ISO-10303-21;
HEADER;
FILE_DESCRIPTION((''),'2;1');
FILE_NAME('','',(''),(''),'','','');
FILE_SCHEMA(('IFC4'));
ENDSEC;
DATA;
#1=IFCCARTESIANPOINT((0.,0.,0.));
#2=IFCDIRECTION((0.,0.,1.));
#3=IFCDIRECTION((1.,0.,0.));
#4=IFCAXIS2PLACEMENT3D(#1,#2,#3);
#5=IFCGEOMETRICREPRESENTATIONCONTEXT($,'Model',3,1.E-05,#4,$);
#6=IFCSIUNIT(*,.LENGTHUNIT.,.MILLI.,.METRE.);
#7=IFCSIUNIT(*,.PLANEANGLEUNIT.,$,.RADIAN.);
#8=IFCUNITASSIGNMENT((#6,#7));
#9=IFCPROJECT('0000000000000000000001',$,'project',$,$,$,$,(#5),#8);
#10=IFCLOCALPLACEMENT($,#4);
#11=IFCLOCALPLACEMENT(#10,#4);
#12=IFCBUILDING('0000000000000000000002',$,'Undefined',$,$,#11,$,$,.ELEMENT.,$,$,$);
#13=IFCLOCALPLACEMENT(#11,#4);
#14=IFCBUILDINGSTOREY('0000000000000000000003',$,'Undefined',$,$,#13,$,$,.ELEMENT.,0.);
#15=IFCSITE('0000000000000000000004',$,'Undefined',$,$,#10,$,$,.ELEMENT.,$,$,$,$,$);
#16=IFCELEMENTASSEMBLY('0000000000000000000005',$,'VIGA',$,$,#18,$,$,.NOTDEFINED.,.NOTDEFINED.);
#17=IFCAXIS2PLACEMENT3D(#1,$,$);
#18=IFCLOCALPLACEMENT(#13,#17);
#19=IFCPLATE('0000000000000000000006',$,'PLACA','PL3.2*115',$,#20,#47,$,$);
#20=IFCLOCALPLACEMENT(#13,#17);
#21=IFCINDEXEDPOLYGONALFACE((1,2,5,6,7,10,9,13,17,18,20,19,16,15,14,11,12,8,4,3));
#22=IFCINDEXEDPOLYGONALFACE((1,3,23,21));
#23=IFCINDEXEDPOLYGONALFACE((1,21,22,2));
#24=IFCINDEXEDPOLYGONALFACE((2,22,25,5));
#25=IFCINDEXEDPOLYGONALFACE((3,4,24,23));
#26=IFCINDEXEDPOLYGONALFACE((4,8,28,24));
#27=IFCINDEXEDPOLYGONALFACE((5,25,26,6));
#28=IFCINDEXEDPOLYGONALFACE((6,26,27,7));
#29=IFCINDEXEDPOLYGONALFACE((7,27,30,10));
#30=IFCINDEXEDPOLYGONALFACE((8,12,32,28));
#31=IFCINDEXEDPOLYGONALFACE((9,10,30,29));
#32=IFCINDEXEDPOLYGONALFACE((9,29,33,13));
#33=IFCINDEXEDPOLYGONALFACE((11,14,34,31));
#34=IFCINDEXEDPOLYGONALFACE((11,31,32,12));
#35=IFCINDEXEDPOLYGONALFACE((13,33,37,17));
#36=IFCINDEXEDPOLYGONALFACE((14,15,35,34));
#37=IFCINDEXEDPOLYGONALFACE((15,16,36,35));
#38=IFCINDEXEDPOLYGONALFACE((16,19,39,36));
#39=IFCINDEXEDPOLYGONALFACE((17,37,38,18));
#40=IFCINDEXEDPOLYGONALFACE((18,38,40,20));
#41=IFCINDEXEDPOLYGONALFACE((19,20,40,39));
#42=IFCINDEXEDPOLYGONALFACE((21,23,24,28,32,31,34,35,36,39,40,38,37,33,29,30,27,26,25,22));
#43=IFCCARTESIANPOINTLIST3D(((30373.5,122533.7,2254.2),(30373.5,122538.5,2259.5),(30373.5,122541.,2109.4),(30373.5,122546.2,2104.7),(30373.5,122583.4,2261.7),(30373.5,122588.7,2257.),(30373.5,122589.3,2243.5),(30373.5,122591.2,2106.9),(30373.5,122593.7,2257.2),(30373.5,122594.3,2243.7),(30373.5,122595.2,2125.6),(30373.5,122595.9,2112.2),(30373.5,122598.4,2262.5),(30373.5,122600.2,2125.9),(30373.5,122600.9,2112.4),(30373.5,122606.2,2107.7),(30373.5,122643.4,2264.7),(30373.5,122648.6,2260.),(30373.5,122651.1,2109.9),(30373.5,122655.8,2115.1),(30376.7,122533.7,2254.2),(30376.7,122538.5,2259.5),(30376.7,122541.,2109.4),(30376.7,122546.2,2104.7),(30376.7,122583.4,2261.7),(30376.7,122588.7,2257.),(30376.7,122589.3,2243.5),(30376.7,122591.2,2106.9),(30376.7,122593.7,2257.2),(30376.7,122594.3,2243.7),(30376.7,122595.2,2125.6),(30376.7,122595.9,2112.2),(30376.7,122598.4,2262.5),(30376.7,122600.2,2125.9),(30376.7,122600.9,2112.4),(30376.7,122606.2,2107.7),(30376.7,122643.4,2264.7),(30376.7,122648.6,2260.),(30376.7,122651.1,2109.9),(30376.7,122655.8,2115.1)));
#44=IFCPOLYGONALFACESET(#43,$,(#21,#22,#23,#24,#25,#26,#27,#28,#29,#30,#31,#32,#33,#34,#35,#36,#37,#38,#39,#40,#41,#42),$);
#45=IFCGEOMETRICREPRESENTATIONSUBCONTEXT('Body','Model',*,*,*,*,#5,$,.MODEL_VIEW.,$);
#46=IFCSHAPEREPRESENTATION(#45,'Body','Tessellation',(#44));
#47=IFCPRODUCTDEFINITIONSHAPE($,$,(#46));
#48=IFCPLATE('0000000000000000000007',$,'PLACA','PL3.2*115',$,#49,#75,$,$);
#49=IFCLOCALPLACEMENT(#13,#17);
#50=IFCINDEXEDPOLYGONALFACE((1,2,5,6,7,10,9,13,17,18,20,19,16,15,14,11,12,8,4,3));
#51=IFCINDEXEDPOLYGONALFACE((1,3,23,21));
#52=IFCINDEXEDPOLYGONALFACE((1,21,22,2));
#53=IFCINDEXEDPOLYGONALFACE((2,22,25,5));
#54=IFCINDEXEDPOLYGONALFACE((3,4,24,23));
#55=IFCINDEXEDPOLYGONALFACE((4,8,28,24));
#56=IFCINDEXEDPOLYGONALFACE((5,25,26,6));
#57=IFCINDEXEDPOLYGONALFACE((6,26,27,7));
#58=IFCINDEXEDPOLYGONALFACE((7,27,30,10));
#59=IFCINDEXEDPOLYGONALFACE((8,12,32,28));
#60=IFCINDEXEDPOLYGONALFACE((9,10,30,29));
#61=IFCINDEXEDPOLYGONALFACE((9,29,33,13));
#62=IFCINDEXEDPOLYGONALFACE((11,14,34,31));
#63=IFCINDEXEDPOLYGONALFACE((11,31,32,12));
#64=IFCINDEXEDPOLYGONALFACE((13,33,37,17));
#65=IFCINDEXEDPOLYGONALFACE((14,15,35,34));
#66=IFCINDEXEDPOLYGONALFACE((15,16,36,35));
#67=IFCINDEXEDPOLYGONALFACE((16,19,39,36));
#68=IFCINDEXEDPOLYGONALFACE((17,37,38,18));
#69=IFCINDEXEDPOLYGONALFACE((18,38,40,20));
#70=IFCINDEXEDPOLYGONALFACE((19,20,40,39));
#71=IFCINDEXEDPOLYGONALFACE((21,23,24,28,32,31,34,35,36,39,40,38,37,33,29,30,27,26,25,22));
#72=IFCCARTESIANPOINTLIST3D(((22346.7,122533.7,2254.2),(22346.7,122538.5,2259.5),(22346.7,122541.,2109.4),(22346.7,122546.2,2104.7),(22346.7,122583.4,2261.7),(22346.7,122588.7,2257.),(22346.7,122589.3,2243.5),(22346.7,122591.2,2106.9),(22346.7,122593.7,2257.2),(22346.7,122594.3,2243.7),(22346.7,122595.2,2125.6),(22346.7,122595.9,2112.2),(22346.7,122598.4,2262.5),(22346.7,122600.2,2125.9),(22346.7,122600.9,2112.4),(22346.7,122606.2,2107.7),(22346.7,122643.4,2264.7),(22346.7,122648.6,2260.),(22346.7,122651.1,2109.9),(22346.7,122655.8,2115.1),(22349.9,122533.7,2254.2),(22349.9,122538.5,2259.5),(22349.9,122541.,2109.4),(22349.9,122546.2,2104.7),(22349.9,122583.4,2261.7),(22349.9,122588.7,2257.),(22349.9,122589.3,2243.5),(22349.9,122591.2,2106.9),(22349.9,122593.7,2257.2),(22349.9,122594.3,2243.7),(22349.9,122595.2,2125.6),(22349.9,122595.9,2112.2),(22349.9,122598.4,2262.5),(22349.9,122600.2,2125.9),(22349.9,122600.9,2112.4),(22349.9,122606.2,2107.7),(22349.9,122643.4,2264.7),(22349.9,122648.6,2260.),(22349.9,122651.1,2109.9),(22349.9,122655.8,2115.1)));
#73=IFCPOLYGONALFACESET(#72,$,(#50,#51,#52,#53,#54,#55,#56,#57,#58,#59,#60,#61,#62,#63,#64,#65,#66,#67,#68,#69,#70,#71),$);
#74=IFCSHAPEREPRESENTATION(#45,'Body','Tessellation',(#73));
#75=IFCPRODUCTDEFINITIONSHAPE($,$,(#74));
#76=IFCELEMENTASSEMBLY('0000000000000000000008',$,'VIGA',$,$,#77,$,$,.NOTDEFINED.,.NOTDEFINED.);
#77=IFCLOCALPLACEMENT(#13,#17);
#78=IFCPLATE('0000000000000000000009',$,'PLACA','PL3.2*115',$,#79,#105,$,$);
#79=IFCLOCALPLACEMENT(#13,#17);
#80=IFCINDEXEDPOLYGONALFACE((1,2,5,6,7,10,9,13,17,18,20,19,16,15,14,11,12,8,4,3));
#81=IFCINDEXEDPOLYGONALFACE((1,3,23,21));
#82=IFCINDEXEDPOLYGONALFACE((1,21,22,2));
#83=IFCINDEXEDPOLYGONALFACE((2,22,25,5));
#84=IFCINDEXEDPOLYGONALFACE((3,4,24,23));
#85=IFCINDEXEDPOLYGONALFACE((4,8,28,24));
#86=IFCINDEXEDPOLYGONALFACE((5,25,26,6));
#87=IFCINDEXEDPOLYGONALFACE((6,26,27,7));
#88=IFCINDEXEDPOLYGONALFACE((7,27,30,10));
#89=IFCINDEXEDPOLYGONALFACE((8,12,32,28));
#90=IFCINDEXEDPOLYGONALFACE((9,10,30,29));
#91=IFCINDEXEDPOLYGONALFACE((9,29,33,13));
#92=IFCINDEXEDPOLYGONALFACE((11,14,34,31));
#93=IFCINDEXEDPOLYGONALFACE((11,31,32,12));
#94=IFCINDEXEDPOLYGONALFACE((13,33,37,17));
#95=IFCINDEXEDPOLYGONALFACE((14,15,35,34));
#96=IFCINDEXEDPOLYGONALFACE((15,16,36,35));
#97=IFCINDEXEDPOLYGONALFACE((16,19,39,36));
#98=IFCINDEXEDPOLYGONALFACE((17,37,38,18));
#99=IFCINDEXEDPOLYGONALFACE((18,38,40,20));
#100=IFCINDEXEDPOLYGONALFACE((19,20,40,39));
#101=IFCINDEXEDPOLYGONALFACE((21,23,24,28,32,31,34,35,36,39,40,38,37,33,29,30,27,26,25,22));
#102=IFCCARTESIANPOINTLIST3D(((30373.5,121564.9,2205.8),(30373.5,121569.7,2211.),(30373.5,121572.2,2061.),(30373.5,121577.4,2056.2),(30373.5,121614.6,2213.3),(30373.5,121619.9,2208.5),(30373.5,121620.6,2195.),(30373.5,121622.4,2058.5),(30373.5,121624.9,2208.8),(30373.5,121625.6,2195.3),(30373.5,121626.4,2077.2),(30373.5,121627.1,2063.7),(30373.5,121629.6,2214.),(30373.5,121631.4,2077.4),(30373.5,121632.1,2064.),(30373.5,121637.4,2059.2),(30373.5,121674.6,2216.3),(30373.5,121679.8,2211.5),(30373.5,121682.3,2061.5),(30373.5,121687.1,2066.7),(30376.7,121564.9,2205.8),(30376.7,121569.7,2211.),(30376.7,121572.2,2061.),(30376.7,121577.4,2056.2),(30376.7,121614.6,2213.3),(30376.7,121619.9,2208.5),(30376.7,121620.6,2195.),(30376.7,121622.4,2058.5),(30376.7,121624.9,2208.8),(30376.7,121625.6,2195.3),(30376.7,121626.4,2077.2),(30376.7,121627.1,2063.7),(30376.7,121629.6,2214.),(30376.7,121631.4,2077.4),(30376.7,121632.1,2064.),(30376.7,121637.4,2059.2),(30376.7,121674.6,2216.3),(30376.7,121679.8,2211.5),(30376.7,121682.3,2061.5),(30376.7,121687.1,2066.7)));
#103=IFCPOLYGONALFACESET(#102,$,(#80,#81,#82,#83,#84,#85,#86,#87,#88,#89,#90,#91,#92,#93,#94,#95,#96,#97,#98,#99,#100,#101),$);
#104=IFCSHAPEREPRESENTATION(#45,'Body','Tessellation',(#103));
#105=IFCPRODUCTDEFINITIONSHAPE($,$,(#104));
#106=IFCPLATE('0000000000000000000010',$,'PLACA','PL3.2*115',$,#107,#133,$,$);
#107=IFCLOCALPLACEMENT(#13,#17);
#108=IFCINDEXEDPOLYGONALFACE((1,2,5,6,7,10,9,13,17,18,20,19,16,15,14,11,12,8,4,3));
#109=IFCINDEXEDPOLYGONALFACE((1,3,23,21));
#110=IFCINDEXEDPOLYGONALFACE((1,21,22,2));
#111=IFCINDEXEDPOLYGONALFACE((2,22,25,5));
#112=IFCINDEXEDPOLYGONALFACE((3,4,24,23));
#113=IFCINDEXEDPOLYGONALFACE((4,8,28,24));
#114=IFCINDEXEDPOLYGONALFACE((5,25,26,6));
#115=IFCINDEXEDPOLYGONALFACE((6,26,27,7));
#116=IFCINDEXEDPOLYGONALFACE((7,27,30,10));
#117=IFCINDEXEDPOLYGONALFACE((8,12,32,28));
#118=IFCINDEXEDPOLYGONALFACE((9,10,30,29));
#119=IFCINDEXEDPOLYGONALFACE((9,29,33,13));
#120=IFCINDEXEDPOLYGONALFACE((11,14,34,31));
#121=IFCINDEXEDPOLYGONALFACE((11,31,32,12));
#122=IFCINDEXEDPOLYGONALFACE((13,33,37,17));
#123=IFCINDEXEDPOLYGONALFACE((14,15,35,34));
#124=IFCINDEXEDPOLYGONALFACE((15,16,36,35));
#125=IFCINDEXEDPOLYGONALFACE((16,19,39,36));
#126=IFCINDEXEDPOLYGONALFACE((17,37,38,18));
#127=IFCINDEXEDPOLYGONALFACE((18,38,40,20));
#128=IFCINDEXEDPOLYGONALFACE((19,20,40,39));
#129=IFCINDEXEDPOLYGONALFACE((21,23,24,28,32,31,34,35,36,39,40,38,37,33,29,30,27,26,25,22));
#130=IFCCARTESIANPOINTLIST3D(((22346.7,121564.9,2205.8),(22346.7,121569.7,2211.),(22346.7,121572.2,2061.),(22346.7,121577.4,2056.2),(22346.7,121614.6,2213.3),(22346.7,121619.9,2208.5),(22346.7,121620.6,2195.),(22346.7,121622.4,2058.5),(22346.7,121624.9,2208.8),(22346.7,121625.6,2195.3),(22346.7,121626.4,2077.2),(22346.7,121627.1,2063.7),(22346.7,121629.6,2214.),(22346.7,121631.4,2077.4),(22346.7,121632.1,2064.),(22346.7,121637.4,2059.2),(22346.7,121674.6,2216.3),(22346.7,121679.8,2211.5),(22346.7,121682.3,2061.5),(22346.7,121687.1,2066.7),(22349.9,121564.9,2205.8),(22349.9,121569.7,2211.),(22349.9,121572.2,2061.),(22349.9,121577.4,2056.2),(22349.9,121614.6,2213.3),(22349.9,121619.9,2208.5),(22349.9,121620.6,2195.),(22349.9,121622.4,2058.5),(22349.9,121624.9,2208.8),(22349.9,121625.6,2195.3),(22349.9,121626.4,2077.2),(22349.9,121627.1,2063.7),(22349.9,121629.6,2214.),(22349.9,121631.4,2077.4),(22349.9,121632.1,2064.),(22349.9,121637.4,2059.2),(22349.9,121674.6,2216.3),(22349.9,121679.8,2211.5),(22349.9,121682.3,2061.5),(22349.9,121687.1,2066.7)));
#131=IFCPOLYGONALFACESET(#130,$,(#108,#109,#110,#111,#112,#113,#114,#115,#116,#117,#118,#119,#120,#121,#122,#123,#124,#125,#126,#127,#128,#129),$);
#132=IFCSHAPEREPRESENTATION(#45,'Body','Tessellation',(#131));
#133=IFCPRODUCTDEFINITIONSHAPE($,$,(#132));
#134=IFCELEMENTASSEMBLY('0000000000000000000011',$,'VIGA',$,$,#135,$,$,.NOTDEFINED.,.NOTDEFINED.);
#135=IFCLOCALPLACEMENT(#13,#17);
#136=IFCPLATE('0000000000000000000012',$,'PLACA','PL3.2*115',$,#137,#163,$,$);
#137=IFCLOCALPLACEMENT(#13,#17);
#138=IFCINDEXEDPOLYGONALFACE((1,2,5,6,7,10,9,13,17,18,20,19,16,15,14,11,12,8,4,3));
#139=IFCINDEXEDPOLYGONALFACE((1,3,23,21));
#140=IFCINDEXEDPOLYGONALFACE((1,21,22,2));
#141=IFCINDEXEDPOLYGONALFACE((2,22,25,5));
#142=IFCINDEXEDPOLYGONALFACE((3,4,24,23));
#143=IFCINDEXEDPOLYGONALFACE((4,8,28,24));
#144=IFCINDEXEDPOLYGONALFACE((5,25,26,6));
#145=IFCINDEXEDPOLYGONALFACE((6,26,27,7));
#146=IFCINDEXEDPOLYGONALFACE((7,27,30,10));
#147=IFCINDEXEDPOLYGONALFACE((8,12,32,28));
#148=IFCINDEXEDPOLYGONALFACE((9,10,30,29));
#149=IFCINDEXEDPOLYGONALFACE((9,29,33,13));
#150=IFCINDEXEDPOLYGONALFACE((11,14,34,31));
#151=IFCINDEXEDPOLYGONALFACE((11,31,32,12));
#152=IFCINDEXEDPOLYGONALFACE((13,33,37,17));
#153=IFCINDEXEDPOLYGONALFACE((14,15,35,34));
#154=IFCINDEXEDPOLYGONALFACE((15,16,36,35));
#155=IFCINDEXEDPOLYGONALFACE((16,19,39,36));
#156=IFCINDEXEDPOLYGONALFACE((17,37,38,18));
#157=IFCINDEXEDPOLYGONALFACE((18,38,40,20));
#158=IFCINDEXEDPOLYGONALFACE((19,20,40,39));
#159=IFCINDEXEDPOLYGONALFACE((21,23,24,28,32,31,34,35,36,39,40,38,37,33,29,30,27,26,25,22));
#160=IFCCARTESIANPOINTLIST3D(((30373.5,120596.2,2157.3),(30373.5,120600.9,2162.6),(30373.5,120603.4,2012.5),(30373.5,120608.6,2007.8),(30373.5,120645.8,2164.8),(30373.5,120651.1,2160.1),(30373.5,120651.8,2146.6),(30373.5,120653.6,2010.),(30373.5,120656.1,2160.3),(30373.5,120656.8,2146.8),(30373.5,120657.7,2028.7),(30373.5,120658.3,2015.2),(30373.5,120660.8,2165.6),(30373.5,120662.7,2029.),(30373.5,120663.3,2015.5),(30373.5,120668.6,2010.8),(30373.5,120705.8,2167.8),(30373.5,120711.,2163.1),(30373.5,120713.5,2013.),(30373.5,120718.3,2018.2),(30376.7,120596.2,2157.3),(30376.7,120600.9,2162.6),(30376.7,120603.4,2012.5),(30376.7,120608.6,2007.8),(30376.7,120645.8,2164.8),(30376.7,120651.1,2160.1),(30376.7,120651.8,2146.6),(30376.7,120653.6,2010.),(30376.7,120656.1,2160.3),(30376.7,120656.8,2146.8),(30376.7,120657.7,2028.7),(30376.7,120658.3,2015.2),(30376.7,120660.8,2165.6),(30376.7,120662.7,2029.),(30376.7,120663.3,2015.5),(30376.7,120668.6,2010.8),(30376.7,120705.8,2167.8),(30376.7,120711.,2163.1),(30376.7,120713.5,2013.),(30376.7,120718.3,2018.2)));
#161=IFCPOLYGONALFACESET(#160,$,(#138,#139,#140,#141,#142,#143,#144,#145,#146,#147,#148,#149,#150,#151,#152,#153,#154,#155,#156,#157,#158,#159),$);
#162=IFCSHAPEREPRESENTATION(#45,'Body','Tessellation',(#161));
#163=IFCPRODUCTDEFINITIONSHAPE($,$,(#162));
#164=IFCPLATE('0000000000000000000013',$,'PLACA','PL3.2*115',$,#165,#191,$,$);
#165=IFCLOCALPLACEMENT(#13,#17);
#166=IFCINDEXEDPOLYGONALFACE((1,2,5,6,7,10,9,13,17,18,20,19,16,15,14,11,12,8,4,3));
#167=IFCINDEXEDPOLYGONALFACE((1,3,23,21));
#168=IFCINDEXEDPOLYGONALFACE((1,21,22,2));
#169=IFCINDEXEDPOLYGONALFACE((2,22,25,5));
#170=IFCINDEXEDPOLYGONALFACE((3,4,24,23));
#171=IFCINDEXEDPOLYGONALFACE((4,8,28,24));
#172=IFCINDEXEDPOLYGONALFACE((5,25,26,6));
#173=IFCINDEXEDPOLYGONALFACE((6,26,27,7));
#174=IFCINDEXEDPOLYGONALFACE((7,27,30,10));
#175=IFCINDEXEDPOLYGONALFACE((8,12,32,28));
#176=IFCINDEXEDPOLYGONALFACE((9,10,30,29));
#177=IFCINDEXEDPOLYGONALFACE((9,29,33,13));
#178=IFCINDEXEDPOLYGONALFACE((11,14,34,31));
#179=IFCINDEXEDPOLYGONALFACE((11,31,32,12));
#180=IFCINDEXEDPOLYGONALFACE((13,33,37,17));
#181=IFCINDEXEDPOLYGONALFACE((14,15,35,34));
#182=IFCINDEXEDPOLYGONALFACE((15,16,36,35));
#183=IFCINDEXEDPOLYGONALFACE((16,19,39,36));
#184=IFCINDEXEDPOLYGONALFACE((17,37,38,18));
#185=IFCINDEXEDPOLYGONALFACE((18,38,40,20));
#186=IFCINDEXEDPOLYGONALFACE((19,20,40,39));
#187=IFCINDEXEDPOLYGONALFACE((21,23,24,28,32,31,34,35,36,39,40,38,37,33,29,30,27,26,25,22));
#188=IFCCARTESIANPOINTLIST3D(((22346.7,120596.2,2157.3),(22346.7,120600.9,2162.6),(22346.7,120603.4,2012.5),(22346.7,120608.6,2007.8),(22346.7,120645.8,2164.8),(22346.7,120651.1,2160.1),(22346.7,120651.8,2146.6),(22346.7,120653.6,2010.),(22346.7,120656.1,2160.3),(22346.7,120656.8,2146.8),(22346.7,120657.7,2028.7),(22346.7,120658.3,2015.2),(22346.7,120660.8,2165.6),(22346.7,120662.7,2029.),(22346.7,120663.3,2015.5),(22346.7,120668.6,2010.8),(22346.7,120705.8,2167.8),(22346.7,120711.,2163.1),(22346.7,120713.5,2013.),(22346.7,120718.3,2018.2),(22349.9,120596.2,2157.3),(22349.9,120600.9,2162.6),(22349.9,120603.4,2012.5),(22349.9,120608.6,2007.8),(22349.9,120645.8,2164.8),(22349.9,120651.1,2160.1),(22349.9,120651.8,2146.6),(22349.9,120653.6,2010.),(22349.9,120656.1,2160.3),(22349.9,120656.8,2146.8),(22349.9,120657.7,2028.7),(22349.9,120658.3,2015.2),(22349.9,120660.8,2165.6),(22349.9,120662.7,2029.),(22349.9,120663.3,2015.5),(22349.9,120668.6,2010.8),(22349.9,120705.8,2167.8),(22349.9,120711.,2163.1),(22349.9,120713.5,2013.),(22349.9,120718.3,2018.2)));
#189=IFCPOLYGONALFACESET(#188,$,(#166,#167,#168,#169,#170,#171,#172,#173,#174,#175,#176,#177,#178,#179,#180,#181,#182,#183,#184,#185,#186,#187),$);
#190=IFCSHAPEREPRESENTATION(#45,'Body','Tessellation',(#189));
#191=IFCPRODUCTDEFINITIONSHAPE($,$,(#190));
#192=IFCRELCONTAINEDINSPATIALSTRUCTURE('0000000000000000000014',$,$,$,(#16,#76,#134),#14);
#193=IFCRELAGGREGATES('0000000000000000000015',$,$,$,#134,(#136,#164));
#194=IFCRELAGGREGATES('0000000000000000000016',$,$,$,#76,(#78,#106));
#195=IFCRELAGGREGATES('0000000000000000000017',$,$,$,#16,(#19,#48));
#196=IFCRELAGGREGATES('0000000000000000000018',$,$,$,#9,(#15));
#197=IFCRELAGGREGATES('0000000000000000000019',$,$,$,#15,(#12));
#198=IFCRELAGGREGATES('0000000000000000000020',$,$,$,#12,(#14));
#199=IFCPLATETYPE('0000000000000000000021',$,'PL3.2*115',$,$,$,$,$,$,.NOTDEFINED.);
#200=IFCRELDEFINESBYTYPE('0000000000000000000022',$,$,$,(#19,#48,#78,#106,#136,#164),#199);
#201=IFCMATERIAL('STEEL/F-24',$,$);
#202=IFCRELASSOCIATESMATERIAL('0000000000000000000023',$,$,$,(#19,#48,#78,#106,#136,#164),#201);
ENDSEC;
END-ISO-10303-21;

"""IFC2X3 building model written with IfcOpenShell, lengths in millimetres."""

from ifc_helpers import new_model, si_unit, frame, origin_with_axes, place, context, subcontext, project, spatial, polyline, outline, extrude, material, type_object, element, aggregate, save


model = new_model("IFC2X3")

# Units and contexts
model_context = context("Model", 3, precision=1e-05, world=origin_with_axes())
body_context = subcontext(model_context, "Body", "Model", "MODEL_VIEW")
ifc_project = project(units=[si_unit("LENGTHUNIT", "METRE", prefix="MILLI"), si_unit("PLANEANGLEUNIT", "RADIAN")], contexts=[model_context])

# Site, building, storey
site_placement = place(None, origin_with_axes())
site = spatial("IfcSite", under=ifc_project, at=site_placement, Name="Undefined", CompositionType="ELEMENT")
building_placement = place(site_placement, origin_with_axes())
building = spatial("IfcBuilding", under=site, at=building_placement, Name="Undefined", CompositionType="ELEMENT")
storey_placement = place(building_placement, origin_with_axes())
storey = spatial("IfcBuildingStorey", under=building, at=storey_placement, Name="Undefined", CompositionType="ELEMENT", Elevation=0.0)

# Element assemblies, plates
ifc_material_1 = material(Name="STEEL/F-24")
plate_type_1 = type_object("IfcPlateType", Name="PL3.2*115", PredefinedType="NOTDEFINED")
assembly_1_placement = place(storey_placement, origin_with_axes())
assembly_1 = element("IfcElementAssembly", 1, at=assembly_1_placement, inside=storey, Name="VIGA", AssemblyPlace="NOTDEFINED", PredefinedType="NOTDEFINED")
plate_1_placement = place(assembly_1_placement, frame((30375.1, 122533.5, 2259.2), z_axis=(-1.0, 0.0, 0.0), x_axis=(0.0, 0.998752, 0.04995)))
plate_1 = element("IfcPlate", 2, at=plate_1_placement, type_object=plate_type_1, material=ifc_material_1, Name="PLACA", Description="PL3.2*115", context=body_context, shape_type="SweptSolid", body=[
    extrude(outline(polyline([(0.0, 5.0), (5.0, 0.0), (50.0, 0.0), (55.0, 5.0), (55.0, 18.5), (60.0, 18.5), (60.0, 5.0), (65.0, 0.0), (110.0, 0.0), (115.0, 5.0), (115.0, 150.0), (110.0, 155.0), (65.0, 155.0), (60.0, 150.0), (60.0, 136.5), (55.0, 136.5), (55.0, 150.0), (50.0, 155.0), (5.0, 155.0), (0.0, 150.0), (0.0, 5.0)])), frame((0.0, 0.0, -1.6), z_axis=(0.0, 0.0, 1.0), x_axis=(1.0, 0.0, 0.0)), (0.0, 0.0, 1.0), 3.2),
])
plate_2_placement = place(assembly_1_placement, frame((22348.3, 122533.5, 2259.2), z_axis=(-1.0, 0.0, 0.0), x_axis=(0.0, 0.998752, 0.04995)))
plate_2 = element("IfcPlate", 3, at=plate_2_placement, type_object=plate_type_1, material=ifc_material_1, Name="PLACA", Description="PL3.2*115", context=body_context, shape_type="SweptSolid", body=[
    extrude(outline(polyline([(0.0, 5.0), (5.0, 0.0), (50.0, 0.0), (55.0, 5.0), (55.0, 18.5), (60.0, 18.5), (60.0, 5.0), (65.0, 0.0), (110.0, 0.0), (115.0, 5.0), (115.0, 150.0), (110.0, 155.0), (65.0, 155.0), (60.0, 150.0), (60.0, 136.5), (55.0, 136.5), (55.0, 150.0), (50.0, 155.0), (5.0, 155.0), (0.0, 150.0), (0.0, 5.0)])), frame((0.0, 0.0, -1.6), z_axis=(0.0, 0.0, 1.0), x_axis=(1.0, 0.0, 0.0)), (0.0, 0.0, 1.0), 3.2),
])
assembly_2_placement = place(storey_placement, origin_with_axes())
assembly_2 = element("IfcElementAssembly", 4, at=assembly_2_placement, inside=storey, Name="VIGA", AssemblyPlace="NOTDEFINED", PredefinedType="NOTDEFINED")
plate_3_placement = place(assembly_2_placement, frame((30375.1, 121564.7, 2210.8), z_axis=(-1.0, 0.0, 0.0), x_axis=(0.0, 0.998752, 0.04995)))
plate_3 = element("IfcPlate", 5, at=plate_3_placement, type_object=plate_type_1, material=ifc_material_1, Name="PLACA", Description="PL3.2*115", context=body_context, shape_type="SweptSolid", body=[
    extrude(outline(polyline([(0.0, 5.0), (5.0, 0.0), (50.0, 0.0), (55.0, 5.0), (55.0, 18.5), (60.0, 18.5), (60.0, 5.0), (65.0, 0.0), (110.0, 0.0), (115.0, 5.0), (115.0, 150.0), (110.0, 155.0), (65.0, 155.0), (60.0, 150.0), (60.0, 136.5), (55.0, 136.5), (55.0, 150.0), (50.0, 155.0), (5.0, 155.0), (0.0, 150.0), (0.0, 5.0)])), frame((0.0, 0.0, -1.6), z_axis=(0.0, 0.0, 1.0), x_axis=(1.0, 0.0, 0.0)), (0.0, 0.0, 1.0), 3.2),
])
plate_4_placement = place(assembly_2_placement, frame((22348.3, 121564.7, 2210.8), z_axis=(-1.0, 0.0, 0.0), x_axis=(0.0, 0.998752, 0.04995)))
plate_4 = element("IfcPlate", 6, at=plate_4_placement, type_object=plate_type_1, material=ifc_material_1, Name="PLACA", Description="PL3.2*115", context=body_context, shape_type="SweptSolid", body=[
    extrude(outline(polyline([(0.0, 5.0), (5.0, 0.0), (50.0, 0.0), (55.0, 5.0), (55.0, 18.5), (60.0, 18.5), (60.0, 5.0), (65.0, 0.0), (110.0, 0.0), (115.0, 5.0), (115.0, 150.0), (110.0, 155.0), (65.0, 155.0), (60.0, 150.0), (60.0, 136.5), (55.0, 136.5), (55.0, 150.0), (50.0, 155.0), (5.0, 155.0), (0.0, 150.0), (0.0, 5.0)])), frame((0.0, 0.0, -1.6), z_axis=(0.0, 0.0, 1.0), x_axis=(1.0, 0.0, 0.0)), (0.0, 0.0, 1.0), 3.2),
])
assembly_3_placement = place(storey_placement, origin_with_axes())
assembly_3 = element("IfcElementAssembly", 7, at=assembly_3_placement, inside=storey, Name="VIGA", AssemblyPlace="NOTDEFINED", PredefinedType="NOTDEFINED")
plate_5_placement = place(assembly_3_placement, frame((30375.1, 120595.9, 2162.3), z_axis=(-1.0, 0.0, 0.0), x_axis=(0.0, 0.998752, 0.04995)))
plate_5 = element("IfcPlate", 8, at=plate_5_placement, type_object=plate_type_1, material=ifc_material_1, Name="PLACA", Description="PL3.2*115", context=body_context, shape_type="SweptSolid", body=[
    extrude(outline(polyline([(0.0, 5.0), (5.0, 0.0), (50.0, 0.0), (55.0, 5.0), (55.0, 18.5), (60.0, 18.5), (60.0, 5.0), (65.0, 0.0), (110.0, 0.0), (115.0, 5.0), (115.0, 150.0), (110.0, 155.0), (65.0, 155.0), (60.0, 150.0), (60.0, 136.5), (55.0, 136.5), (55.0, 150.0), (50.0, 155.0), (5.0, 155.0), (0.0, 150.0), (0.0, 5.0)])), frame((0.0, 0.0, -1.6), z_axis=(0.0, 0.0, 1.0), x_axis=(1.0, 0.0, 0.0)), (0.0, 0.0, 1.0), 3.2),
])
plate_6_placement = place(assembly_3_placement, frame((22348.3, 120595.9, 2162.3), z_axis=(-1.0, 0.0, 0.0), x_axis=(0.0, 0.998752, 0.04995)))
plate_6 = element("IfcPlate", 9, at=plate_6_placement, type_object=plate_type_1, material=ifc_material_1, Name="PLACA", Description="PL3.2*115", context=body_context, shape_type="SweptSolid", body=[
    extrude(outline(polyline([(0.0, 5.0), (5.0, 0.0), (50.0, 0.0), (55.0, 5.0), (55.0, 18.5), (60.0, 18.5), (60.0, 5.0), (65.0, 0.0), (110.0, 0.0), (115.0, 5.0), (115.0, 150.0), (110.0, 155.0), (65.0, 155.0), (60.0, 150.0), (60.0, 136.5), (55.0, 136.5), (55.0, 150.0), (50.0, 155.0), (5.0, 155.0), (0.0, 150.0), (0.0, 5.0)])), frame((0.0, 0.0, -1.6), z_axis=(0.0, 0.0, 1.0), x_axis=(1.0, 0.0, 0.0)), (0.0, 0.0, 1.0), 3.2),
])

aggregate(assembly_3, [plate_5, plate_6])
aggregate(assembly_2, [plate_3, plate_4])
aggregate(assembly_1, [plate_1, plate_2])

save(model, "model.ifc")
